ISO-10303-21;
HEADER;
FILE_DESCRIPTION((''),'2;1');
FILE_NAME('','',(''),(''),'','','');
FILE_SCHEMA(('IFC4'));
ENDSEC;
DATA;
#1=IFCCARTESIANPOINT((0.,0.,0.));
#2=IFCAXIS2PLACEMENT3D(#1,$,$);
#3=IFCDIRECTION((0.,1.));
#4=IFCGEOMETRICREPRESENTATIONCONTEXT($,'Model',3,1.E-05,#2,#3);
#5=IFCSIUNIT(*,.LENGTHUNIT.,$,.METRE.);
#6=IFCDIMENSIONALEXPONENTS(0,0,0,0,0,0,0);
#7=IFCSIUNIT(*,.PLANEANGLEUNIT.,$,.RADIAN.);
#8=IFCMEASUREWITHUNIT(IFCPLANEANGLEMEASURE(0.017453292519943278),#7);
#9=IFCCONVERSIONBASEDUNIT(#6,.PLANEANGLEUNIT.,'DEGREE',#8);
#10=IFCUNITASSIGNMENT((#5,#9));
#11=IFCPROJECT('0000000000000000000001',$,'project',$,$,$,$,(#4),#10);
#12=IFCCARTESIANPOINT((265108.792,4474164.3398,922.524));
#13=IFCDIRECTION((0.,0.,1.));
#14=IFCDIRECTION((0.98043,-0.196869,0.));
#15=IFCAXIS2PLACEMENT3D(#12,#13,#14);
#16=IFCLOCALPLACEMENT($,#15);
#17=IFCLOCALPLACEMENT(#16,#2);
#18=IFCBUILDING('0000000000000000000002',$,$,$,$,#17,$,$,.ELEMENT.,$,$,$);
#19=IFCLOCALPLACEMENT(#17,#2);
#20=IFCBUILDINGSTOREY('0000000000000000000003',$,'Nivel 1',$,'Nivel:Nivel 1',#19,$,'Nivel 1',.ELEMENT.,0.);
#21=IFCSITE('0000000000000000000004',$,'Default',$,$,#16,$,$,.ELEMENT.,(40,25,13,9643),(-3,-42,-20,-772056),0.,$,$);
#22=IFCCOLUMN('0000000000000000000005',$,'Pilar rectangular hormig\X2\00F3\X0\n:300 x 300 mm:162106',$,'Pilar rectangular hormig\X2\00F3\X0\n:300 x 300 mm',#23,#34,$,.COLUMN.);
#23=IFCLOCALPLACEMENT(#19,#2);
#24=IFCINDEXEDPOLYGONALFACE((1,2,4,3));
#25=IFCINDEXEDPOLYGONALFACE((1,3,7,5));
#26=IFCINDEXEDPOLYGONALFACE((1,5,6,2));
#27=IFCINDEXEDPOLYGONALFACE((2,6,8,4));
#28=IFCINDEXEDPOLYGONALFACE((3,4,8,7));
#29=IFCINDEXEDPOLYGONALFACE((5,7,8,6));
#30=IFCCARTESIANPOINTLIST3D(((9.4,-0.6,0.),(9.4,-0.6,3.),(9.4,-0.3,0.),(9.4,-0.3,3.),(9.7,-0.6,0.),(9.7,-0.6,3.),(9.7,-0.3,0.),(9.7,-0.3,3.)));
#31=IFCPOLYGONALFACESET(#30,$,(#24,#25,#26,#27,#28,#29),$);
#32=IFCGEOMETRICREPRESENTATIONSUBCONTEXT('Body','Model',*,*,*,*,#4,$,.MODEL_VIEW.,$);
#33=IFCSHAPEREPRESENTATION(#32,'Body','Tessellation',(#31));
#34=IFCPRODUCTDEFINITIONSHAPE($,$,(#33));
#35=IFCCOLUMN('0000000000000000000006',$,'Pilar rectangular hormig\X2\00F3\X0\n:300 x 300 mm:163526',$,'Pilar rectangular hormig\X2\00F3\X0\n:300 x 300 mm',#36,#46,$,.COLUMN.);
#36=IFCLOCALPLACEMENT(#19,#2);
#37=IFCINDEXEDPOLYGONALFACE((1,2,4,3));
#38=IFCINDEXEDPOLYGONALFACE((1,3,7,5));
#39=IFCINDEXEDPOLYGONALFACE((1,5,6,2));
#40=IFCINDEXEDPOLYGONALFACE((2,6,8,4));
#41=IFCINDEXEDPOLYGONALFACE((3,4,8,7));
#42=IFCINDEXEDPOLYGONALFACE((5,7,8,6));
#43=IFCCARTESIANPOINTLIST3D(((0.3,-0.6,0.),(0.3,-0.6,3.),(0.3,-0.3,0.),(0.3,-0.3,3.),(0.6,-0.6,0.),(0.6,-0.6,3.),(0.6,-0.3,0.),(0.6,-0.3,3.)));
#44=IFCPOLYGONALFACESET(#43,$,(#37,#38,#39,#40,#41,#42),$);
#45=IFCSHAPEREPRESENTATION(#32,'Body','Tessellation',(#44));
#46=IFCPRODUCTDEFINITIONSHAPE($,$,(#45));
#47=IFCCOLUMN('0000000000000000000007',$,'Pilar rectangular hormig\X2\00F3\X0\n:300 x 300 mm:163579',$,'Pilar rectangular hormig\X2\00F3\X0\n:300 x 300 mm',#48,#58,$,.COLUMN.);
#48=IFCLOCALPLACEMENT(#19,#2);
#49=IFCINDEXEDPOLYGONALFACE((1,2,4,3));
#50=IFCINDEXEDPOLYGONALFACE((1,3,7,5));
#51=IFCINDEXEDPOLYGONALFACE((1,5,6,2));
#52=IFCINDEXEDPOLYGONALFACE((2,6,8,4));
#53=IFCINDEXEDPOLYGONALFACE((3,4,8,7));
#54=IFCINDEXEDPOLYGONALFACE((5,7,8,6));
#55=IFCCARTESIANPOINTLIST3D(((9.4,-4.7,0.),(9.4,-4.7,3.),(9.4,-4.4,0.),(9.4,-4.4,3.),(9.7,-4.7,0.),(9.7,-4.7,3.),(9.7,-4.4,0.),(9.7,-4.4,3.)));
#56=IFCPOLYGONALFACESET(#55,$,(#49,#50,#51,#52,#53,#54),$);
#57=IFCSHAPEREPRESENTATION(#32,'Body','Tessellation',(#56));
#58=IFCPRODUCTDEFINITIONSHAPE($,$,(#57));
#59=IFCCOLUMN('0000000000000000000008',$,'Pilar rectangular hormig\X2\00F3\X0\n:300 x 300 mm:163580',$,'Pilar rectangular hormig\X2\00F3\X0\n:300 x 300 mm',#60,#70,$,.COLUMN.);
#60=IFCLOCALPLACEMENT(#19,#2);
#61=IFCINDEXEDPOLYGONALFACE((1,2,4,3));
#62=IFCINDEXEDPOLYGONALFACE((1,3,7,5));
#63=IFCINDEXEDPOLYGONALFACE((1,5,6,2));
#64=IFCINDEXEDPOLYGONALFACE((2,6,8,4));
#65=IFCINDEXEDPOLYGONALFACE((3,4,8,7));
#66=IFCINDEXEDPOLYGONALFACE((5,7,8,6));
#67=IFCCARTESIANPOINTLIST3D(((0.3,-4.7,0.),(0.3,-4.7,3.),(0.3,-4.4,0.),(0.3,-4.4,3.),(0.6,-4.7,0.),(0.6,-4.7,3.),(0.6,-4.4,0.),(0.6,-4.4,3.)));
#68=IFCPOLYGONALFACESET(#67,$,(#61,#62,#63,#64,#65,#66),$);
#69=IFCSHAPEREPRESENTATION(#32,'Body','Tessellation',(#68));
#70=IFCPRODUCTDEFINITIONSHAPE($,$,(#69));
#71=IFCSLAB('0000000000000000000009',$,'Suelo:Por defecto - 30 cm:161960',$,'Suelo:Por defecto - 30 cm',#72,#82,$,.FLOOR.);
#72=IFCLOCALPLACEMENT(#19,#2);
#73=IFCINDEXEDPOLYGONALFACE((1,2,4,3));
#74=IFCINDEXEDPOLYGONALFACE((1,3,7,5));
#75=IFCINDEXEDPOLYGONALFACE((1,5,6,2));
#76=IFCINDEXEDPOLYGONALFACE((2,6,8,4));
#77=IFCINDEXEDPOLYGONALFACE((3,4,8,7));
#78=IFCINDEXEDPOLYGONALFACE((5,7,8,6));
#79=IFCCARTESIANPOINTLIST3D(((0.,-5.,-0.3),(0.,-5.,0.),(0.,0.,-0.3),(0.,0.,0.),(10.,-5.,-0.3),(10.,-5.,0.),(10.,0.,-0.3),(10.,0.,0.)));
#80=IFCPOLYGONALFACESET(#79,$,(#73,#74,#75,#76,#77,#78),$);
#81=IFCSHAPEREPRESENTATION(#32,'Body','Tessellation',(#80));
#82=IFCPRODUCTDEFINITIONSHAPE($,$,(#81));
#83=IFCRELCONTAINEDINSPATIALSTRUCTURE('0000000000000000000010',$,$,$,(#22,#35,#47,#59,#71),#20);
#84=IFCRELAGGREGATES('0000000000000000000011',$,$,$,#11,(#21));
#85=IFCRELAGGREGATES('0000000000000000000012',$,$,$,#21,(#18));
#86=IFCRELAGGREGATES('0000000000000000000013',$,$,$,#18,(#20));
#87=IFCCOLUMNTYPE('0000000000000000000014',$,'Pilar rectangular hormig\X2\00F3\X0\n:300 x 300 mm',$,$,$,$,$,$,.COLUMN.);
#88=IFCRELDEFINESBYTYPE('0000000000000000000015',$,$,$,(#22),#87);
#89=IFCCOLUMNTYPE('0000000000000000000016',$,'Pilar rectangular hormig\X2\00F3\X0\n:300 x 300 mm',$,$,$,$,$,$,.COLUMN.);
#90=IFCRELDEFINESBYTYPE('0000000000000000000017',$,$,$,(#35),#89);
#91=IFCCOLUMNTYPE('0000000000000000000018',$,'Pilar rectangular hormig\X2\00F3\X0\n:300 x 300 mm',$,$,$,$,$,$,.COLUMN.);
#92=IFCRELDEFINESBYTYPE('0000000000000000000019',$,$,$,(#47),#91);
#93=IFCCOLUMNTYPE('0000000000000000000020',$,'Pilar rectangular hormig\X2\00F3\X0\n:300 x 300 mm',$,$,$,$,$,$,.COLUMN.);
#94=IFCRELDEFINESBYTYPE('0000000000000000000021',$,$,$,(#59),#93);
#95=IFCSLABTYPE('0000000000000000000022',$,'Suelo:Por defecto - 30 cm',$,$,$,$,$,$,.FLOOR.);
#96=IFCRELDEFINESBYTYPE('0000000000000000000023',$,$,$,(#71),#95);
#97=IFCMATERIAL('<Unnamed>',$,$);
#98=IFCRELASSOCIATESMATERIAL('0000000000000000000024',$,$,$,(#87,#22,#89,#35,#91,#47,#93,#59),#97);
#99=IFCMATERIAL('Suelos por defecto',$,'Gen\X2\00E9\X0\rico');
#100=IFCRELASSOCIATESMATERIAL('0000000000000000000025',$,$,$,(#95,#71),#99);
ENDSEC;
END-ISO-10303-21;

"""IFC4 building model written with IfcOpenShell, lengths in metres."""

from ifc_helpers import new_model, entity, si_unit, converted_unit, direction, frame, origin, place, context, subcontext, project, spatial, indexed_curve, outline, extrude, source, transform, mapped, material, type_object, type_shapes, element, save


model = new_model("IFC4")

# Units and contexts
model_context = context("Model", 3, precision=1e-05, world=origin(), true_north=direction((0.0, 1.0)))
body_context = subcontext(model_context, "Body", "Model", "MODEL_VIEW")
ifc_project = project(units=[si_unit("LENGTHUNIT", "METRE"), converted_unit("PLANEANGLEUNIT", "DEGREE", entity("IfcPlaneAngleMeasure", 0.017453292519943278), si_unit("PLANEANGLEUNIT", "RADIAN"), dimensions=[0, 0, 0, 0, 0, 0, 0])], contexts=[model_context])

# Site, building, storey
site_placement = place(None, frame((265108.792, 4474164.3398, 922.524), z_axis=(0.0, 0.0, 1.0), x_axis=(0.98043, -0.196869, 0.0)))
site = spatial("IfcSite", under=ifc_project, at=site_placement, Name="Default", CompositionType="ELEMENT", RefLatitude=(40, 25, 13, 9643), RefLongitude=(-3, -42, -20, -772056), RefElevation=0.0)
building_placement = place(site_placement, origin())
building = spatial("IfcBuilding", under=site, at=building_placement, CompositionType="ELEMENT")
storey_placement = place(building_placement, origin())
storey = spatial("IfcBuildingStorey", under=building, at=storey_placement, Name="Nivel 1", ObjectType="Nivel:Nivel 1", LongName="Nivel 1", CompositionType="ELEMENT", Elevation=0.0)

# Columns
ifc_material_1 = material(Name="<Unnamed>")
column_type_1 = type_object("IfcColumnType", Name="Pilar rectangular hormigón:300 x 300 mm", PredefinedType="COLUMN", material=ifc_material_1)
shared_shape_1 = source(origin(), body_context, "Body", "SweptSolid", [
    extrude(outline(indexed_curve([(-0.15, -0.15), (0.15, -0.15), (0.15, 0.15), (-0.15, 0.15), (-0.15, -0.15)], self_intersect=False)), frame((9.55, -0.45, 0.0), z_axis=(0.0, 0.0, 1.0), x_axis=(0.0, -1.0, 0.0)), (0.0, 0.0, 1.0), 3.0),
])
type_shapes(column_type_1, [shared_shape_1])
column_1_placement = place(storey_placement, origin())
element("IfcColumn", 1, at=column_1_placement, inside=storey, type_object=column_type_1, material=ifc_material_1, Name="Pilar rectangular hormigón:300 x 300 mm:162106", ObjectType="Pilar rectangular hormigón:300 x 300 mm", PredefinedType="COLUMN", context=body_context, shape_type="MappedRepresentation", body=[
    mapped(shared_shape_1, transform((0.0, 0.0, 0.0), scale=1.0)),
])
column_type_2 = type_object("IfcColumnType", Name="Pilar rectangular hormigón:300 x 300 mm", PredefinedType="COLUMN", material=ifc_material_1)
shared_shape_2 = source(origin(), body_context, "Body", "SweptSolid", [
    extrude(outline(indexed_curve([(-0.15, -0.15), (0.15, -0.15), (0.15, 0.15), (-0.15, 0.15), (-0.15, -0.15)], self_intersect=False)), frame((0.45, -0.45, 0.0), z_axis=(0.0, 0.0, 1.0), x_axis=(-1.0, 0.0, 0.0)), (0.0, 0.0, 1.0), 3.0),
])
type_shapes(column_type_2, [shared_shape_2])
column_2_placement = place(storey_placement, origin())
element("IfcColumn", 2, at=column_2_placement, inside=storey, type_object=column_type_2, material=ifc_material_1, Name="Pilar rectangular hormigón:300 x 300 mm:163526", ObjectType="Pilar rectangular hormigón:300 x 300 mm", PredefinedType="COLUMN", context=body_context, shape_type="MappedRepresentation", body=[
    mapped(shared_shape_2, transform((0.0, 0.0, 0.0), scale=1.0)),
])
column_type_3 = type_object("IfcColumnType", Name="Pilar rectangular hormigón:300 x 300 mm", PredefinedType="COLUMN", material=ifc_material_1)
shared_shape_3 = source(origin(), body_context, "Body", "SweptSolid", [
    extrude(outline(indexed_curve([(-0.15, -0.15), (0.15, -0.15), (0.15, 0.15), (-0.15, 0.15), (-0.15, -0.15)], self_intersect=False)), frame((9.55, -4.55, 0.0)), (0.0, 0.0, 1.0), 3.0),
])
type_shapes(column_type_3, [shared_shape_3])
column_3_placement = place(storey_placement, origin())
element("IfcColumn", 3, at=column_3_placement, inside=storey, type_object=column_type_3, material=ifc_material_1, Name="Pilar rectangular hormigón:300 x 300 mm:163579", ObjectType="Pilar rectangular hormigón:300 x 300 mm", PredefinedType="COLUMN", context=body_context, shape_type="MappedRepresentation", body=[
    mapped(shared_shape_3, transform((0.0, 0.0, 0.0), scale=1.0)),
])
column_type_4 = type_object("IfcColumnType", Name="Pilar rectangular hormigón:300 x 300 mm", PredefinedType="COLUMN", material=ifc_material_1)
shared_shape_4 = source(origin(), body_context, "Body", "SweptSolid", [
    extrude(outline(indexed_curve([(-0.15, -0.15), (0.15, -0.15), (0.15, 0.15), (-0.15, 0.15), (-0.15, -0.15)], self_intersect=False)), frame((0.45, -4.55, 0.0), z_axis=(0.0, 0.0, 1.0), x_axis=(0.0, 1.0, 0.0)), (0.0, 0.0, 1.0), 3.0),
])
type_shapes(column_type_4, [shared_shape_4])
column_4_placement = place(storey_placement, origin())
element("IfcColumn", 4, at=column_4_placement, inside=storey, type_object=column_type_4, material=ifc_material_1, Name="Pilar rectangular hormigón:300 x 300 mm:163580", ObjectType="Pilar rectangular hormigón:300 x 300 mm", PredefinedType="COLUMN", context=body_context, shape_type="MappedRepresentation", body=[
    mapped(shared_shape_4, transform((0.0, 0.0, 0.0), scale=1.0)),
])

# Slab
ifc_material_2 = material(Name="Suelos por defecto", Category="Genérico")
slab_type = type_object("IfcSlabType", Name="Suelo:Por defecto - 30 cm", PredefinedType="FLOOR", material=ifc_material_2)
slab_placement = place(storey_placement, origin())
element("IfcSlab", 5, at=slab_placement, inside=storey, type_object=slab_type, material=ifc_material_2, Name="Suelo:Por defecto - 30 cm:161960", ObjectType="Suelo:Por defecto - 30 cm", PredefinedType="FLOOR", context=body_context, shape_type="SweptSolid", body=[
    extrude(outline(indexed_curve([(-2.5, -5.0), (2.5, -5.0), (2.5, 5.0), (-2.5, 5.0), (-2.5, -5.0)], self_intersect=False)), frame((5.0, -2.5, 0.0), z_axis=(0.0, 0.0, -1.0), x_axis=(0.0, 1.0, 0.0)), (0.0, 0.0, 1.0), 0.3),
])

save(model, "model.ifc")
